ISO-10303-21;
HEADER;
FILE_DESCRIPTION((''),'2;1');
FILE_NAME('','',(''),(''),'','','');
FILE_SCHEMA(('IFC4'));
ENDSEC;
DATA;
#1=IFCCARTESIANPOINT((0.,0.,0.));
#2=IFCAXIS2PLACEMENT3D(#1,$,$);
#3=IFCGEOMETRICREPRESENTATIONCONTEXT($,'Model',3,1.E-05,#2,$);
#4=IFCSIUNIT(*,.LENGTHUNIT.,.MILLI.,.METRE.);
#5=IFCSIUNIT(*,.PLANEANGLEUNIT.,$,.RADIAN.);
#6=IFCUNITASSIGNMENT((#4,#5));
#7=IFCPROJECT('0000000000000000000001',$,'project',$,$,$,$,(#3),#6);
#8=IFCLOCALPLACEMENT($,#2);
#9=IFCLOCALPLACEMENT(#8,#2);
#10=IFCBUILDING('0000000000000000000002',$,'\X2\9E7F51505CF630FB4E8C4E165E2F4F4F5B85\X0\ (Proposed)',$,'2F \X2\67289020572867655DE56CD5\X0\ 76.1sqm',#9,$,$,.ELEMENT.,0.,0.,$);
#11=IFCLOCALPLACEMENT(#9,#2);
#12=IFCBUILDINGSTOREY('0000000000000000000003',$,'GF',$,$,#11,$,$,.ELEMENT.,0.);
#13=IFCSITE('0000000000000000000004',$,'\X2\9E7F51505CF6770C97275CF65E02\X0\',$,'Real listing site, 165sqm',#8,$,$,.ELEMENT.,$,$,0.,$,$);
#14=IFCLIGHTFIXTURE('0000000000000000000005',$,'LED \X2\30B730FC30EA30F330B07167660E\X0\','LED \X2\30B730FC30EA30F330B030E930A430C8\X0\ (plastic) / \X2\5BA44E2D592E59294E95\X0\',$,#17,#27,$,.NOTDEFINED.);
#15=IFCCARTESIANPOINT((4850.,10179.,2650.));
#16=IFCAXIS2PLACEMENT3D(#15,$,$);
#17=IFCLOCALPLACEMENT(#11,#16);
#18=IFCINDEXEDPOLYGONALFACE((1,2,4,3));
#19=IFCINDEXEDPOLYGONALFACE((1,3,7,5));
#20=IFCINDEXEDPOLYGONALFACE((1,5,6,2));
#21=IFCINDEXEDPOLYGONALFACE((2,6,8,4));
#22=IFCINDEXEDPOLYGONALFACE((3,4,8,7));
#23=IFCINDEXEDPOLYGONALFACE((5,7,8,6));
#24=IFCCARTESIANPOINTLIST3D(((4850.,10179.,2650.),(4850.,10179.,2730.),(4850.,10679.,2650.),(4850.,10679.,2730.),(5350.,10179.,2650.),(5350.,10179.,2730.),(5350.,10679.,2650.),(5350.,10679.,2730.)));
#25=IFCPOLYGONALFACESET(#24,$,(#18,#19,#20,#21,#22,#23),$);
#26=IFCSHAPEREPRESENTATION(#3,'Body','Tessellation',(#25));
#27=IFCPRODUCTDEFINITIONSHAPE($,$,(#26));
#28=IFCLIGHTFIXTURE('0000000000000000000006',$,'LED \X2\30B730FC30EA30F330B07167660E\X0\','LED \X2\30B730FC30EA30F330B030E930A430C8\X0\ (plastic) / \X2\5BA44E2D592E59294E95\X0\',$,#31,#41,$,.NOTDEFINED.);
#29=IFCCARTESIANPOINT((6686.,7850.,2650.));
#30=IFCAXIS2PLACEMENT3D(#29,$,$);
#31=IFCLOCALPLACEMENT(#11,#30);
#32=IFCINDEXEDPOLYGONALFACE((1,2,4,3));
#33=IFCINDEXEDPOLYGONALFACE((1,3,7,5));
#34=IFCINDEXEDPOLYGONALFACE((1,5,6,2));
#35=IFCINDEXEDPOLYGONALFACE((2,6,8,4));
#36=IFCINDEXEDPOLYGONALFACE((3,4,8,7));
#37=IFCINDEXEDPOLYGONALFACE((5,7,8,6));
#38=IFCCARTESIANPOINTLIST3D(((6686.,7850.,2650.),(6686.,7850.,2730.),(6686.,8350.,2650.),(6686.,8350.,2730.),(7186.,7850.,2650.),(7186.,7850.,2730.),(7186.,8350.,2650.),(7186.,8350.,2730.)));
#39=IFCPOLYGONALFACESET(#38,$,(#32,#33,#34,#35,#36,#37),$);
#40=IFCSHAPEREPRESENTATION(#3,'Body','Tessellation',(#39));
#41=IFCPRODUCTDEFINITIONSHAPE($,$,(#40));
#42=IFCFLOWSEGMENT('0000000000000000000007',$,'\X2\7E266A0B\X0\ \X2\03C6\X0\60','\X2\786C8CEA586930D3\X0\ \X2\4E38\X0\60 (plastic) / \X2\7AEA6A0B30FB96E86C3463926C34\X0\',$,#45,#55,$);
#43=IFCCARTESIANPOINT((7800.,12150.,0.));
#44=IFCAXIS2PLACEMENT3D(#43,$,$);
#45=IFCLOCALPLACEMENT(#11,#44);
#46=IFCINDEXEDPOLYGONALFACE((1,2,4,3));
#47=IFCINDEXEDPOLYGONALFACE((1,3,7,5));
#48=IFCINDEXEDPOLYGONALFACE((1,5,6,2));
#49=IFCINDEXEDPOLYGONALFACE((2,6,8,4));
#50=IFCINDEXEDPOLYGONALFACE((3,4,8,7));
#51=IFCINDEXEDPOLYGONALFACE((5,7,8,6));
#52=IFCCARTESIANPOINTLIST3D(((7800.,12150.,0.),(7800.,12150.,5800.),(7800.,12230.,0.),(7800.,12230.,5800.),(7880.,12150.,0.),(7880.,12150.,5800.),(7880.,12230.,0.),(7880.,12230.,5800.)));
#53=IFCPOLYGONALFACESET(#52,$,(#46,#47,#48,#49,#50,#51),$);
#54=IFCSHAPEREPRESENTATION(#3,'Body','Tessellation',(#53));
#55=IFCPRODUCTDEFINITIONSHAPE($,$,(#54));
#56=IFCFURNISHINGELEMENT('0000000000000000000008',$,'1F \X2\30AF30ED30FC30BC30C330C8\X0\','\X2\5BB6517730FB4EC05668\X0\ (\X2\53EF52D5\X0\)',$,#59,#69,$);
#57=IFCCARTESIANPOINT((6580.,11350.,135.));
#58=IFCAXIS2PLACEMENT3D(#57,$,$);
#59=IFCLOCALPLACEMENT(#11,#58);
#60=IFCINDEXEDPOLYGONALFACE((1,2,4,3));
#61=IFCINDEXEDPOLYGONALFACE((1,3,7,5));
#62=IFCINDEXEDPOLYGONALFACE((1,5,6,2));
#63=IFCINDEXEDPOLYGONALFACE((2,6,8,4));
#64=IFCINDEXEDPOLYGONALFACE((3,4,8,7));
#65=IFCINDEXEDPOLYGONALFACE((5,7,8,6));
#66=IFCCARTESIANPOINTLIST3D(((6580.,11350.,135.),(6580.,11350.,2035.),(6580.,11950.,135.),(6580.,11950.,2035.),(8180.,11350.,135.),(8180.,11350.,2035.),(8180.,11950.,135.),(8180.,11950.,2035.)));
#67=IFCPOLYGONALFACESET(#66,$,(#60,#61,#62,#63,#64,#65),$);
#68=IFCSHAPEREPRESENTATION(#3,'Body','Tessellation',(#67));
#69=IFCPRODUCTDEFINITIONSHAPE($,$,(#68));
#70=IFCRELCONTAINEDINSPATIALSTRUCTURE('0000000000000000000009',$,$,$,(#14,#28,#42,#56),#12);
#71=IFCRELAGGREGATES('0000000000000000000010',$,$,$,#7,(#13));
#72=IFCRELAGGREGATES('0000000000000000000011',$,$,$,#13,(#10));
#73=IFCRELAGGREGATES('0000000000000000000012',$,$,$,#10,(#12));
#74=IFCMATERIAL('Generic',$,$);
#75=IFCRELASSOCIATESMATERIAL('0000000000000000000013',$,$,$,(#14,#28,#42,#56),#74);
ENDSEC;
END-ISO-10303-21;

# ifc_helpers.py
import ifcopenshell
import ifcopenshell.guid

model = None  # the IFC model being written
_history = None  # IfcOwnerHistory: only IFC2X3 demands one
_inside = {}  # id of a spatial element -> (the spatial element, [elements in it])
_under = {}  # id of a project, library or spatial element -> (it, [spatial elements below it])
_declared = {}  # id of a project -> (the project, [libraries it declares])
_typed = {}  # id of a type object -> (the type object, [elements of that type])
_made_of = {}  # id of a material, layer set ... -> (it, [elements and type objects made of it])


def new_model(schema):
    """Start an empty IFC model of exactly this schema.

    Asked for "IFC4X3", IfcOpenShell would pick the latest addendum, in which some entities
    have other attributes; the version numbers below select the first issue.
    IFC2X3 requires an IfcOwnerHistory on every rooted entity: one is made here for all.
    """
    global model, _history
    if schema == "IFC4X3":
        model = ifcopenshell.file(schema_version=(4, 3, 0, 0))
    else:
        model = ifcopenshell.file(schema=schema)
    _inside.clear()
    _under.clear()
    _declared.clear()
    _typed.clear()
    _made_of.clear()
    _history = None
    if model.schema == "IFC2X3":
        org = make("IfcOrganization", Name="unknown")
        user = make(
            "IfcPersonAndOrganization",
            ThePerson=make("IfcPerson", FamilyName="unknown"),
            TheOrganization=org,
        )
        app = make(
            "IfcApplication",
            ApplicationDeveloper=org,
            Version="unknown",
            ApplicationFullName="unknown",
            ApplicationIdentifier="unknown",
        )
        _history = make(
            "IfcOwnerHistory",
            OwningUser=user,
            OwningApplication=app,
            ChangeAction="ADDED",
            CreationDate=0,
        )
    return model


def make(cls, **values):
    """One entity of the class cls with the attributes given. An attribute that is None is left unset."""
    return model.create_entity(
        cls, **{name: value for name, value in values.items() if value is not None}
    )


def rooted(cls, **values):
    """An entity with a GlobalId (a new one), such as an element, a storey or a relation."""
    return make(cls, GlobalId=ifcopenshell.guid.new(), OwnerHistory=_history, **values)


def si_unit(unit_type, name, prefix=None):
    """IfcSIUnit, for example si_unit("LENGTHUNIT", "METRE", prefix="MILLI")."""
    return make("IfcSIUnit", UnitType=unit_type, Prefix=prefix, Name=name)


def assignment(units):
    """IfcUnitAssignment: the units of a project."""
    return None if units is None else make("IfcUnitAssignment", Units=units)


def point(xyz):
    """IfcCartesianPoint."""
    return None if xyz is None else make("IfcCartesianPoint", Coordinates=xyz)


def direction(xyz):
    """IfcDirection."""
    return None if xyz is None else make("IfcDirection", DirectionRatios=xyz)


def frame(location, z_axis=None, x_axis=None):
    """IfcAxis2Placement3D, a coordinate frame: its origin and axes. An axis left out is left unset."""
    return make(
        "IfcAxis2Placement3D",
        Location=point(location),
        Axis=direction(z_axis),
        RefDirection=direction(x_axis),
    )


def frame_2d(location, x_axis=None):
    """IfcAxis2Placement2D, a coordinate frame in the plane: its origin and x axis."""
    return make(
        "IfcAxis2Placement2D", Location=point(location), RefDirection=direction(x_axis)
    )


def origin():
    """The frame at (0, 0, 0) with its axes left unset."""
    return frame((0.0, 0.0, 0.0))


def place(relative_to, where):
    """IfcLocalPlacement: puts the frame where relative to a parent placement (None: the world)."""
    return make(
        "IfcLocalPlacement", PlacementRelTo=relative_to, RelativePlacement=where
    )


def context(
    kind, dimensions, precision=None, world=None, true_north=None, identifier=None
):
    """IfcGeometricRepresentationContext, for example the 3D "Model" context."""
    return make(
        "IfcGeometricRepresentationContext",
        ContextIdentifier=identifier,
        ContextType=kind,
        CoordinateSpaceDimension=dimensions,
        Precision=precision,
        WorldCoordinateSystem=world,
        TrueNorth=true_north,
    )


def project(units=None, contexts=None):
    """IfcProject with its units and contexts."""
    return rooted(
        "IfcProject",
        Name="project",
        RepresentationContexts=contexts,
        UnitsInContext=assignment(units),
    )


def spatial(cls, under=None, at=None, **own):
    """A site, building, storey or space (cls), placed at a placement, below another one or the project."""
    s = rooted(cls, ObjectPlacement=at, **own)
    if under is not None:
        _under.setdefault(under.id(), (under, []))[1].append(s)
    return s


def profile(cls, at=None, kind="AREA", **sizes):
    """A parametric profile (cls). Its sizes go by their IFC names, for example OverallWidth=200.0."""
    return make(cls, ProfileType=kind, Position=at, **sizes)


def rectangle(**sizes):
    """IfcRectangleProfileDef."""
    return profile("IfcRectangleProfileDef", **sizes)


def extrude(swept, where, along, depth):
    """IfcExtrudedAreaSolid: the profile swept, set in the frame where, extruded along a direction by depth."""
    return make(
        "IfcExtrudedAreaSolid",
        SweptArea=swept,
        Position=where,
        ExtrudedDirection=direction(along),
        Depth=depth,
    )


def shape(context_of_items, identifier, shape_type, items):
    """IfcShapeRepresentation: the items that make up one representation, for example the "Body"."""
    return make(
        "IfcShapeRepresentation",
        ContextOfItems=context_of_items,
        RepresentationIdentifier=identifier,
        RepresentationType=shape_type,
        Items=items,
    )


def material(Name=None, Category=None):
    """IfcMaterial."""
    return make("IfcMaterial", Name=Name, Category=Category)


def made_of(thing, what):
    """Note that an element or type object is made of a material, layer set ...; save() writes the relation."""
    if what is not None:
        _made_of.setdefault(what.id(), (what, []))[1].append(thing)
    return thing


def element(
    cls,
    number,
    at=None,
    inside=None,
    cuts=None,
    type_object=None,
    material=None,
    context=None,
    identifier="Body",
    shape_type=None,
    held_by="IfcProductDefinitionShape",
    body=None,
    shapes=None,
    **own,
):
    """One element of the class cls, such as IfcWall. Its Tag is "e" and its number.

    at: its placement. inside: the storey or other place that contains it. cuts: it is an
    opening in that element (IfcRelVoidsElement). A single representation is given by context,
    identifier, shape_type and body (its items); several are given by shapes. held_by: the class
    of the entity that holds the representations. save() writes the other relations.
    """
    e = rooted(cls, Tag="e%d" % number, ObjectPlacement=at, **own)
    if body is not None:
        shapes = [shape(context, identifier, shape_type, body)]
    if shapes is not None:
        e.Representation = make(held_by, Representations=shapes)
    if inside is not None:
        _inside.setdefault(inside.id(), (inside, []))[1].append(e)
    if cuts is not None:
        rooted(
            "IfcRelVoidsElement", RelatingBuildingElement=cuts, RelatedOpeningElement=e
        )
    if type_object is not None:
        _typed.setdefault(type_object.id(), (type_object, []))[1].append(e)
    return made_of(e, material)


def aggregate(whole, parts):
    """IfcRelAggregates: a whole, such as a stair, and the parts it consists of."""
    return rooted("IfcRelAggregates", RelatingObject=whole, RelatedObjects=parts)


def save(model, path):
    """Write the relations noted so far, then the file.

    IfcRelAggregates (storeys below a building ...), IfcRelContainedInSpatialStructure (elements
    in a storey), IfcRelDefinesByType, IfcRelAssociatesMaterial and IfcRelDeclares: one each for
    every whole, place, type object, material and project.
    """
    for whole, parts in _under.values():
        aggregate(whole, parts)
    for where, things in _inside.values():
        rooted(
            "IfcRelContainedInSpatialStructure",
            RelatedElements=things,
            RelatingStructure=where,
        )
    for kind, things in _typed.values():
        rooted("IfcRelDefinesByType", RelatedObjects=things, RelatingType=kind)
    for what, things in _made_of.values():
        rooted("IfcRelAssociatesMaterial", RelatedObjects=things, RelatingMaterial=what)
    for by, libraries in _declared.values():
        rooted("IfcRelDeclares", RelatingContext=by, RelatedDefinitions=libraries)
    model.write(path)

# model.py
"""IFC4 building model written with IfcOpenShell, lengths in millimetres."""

from ifc_helpers import new_model, si_unit, frame, frame_2d, origin, place, context, project, spatial, rectangle, extrude, material, element, save


model = new_model("IFC4")

# Units and contexts
model_context = context("Model", 3, precision=1e-05, world=origin())
ifc_project = project(units=[si_unit("LENGTHUNIT", "METRE", prefix="MILLI"), si_unit("PLANEANGLEUNIT", "RADIAN")], contexts=[model_context])

# Site, building, storey
site_placement = place(None, origin())
site = spatial("IfcSite", under=ifc_project, at=site_placement, Name="鹿児島県霧島市", ObjectType="Real listing site, 165sqm", CompositionType="ELEMENT", RefElevation=0.0)
building_placement = place(site_placement, origin())
building = spatial("IfcBuilding", under=site, at=building_placement, Name="鹿児島・二世帯住宅 (Proposed)", ObjectType="2F 木造在来工法 76.1sqm", CompositionType="ELEMENT", ElevationOfRefHeight=0.0, ElevationOfTerrain=0.0)
storey_placement = place(building_placement, origin())
storey = spatial("IfcBuildingStorey", under=building, at=storey_placement, Name="GF", CompositionType="ELEMENT", Elevation=0.0)

# Shared definitions
ifc_material_1 = material(Name="Generic")

# Light fixtures
light_fixture_1_placement = place(storey_placement, frame((4850.0, 10179.0, 2650.0)))
element("IfcLightFixture", 1, at=light_fixture_1_placement, inside=storey, material=ifc_material_1, Name="LED シーリング照明", Description="LED シーリングライト (plastic) / 室中央天井", PredefinedType="NOTDEFINED", context=model_context, shape_type="SweptSolid", body=[
    extrude(rectangle(XDim=500.0, YDim=500.0, at=frame_2d((250.0, 250.0))), frame((4850.0, 10179.0, 2650.0)), (0.0, 0.0, 1.0), 80.0),
])
light_fixture_2_placement = place(storey_placement, frame((6686.0, 7850.0, 2650.0)))
element("IfcLightFixture", 2, at=light_fixture_2_placement, inside=storey, material=ifc_material_1, Name="LED シーリング照明", Description="LED シーリングライト (plastic) / 室中央天井", PredefinedType="NOTDEFINED", context=model_context, shape_type="SweptSolid", body=[
    extrude(rectangle(XDim=500.0, YDim=500.0, at=frame_2d((250.0, 250.0))), frame((6686.0, 7850.0, 2650.0)), (0.0, 0.0, 1.0), 80.0),
])

# Flow segment
flow_segment_placement = place(storey_placement, frame((7800.0, 12150.0, 0.0)))
element("IfcFlowSegment", 3, at=flow_segment_placement, inside=storey, material=ifc_material_1, Name="縦樋 φ60", Description="硬質塩ビ 丸60 (plastic) / 竪樋・雨水排水", context=model_context, shape_type="SweptSolid", body=[
    extrude(rectangle(XDim=80.0, YDim=80.0, at=frame_2d((40.0, 40.0))), frame((7800.0, 12150.0, 0.0)), (0.0, 0.0, 1.0), 5800.0),
])

# Furnishing element
furnishing_placement = place(storey_placement, frame((6580.0, 11350.0, 135.0)))
element("IfcFurnishingElement", 4, at=furnishing_placement, inside=storey, material=ifc_material_1, Name="1F クローゼット", Description="家具・什器 (可動)", context=model_context, shape_type="SweptSolid", body=[
    extrude(rectangle(XDim=1600.0, YDim=600.0, at=frame_2d((800.0, 300.0))), frame((6580.0, 11350.0, 135.0)), (0.0, 0.0, 1.0), 1900.0),
])

save(model, "model.ifc")
